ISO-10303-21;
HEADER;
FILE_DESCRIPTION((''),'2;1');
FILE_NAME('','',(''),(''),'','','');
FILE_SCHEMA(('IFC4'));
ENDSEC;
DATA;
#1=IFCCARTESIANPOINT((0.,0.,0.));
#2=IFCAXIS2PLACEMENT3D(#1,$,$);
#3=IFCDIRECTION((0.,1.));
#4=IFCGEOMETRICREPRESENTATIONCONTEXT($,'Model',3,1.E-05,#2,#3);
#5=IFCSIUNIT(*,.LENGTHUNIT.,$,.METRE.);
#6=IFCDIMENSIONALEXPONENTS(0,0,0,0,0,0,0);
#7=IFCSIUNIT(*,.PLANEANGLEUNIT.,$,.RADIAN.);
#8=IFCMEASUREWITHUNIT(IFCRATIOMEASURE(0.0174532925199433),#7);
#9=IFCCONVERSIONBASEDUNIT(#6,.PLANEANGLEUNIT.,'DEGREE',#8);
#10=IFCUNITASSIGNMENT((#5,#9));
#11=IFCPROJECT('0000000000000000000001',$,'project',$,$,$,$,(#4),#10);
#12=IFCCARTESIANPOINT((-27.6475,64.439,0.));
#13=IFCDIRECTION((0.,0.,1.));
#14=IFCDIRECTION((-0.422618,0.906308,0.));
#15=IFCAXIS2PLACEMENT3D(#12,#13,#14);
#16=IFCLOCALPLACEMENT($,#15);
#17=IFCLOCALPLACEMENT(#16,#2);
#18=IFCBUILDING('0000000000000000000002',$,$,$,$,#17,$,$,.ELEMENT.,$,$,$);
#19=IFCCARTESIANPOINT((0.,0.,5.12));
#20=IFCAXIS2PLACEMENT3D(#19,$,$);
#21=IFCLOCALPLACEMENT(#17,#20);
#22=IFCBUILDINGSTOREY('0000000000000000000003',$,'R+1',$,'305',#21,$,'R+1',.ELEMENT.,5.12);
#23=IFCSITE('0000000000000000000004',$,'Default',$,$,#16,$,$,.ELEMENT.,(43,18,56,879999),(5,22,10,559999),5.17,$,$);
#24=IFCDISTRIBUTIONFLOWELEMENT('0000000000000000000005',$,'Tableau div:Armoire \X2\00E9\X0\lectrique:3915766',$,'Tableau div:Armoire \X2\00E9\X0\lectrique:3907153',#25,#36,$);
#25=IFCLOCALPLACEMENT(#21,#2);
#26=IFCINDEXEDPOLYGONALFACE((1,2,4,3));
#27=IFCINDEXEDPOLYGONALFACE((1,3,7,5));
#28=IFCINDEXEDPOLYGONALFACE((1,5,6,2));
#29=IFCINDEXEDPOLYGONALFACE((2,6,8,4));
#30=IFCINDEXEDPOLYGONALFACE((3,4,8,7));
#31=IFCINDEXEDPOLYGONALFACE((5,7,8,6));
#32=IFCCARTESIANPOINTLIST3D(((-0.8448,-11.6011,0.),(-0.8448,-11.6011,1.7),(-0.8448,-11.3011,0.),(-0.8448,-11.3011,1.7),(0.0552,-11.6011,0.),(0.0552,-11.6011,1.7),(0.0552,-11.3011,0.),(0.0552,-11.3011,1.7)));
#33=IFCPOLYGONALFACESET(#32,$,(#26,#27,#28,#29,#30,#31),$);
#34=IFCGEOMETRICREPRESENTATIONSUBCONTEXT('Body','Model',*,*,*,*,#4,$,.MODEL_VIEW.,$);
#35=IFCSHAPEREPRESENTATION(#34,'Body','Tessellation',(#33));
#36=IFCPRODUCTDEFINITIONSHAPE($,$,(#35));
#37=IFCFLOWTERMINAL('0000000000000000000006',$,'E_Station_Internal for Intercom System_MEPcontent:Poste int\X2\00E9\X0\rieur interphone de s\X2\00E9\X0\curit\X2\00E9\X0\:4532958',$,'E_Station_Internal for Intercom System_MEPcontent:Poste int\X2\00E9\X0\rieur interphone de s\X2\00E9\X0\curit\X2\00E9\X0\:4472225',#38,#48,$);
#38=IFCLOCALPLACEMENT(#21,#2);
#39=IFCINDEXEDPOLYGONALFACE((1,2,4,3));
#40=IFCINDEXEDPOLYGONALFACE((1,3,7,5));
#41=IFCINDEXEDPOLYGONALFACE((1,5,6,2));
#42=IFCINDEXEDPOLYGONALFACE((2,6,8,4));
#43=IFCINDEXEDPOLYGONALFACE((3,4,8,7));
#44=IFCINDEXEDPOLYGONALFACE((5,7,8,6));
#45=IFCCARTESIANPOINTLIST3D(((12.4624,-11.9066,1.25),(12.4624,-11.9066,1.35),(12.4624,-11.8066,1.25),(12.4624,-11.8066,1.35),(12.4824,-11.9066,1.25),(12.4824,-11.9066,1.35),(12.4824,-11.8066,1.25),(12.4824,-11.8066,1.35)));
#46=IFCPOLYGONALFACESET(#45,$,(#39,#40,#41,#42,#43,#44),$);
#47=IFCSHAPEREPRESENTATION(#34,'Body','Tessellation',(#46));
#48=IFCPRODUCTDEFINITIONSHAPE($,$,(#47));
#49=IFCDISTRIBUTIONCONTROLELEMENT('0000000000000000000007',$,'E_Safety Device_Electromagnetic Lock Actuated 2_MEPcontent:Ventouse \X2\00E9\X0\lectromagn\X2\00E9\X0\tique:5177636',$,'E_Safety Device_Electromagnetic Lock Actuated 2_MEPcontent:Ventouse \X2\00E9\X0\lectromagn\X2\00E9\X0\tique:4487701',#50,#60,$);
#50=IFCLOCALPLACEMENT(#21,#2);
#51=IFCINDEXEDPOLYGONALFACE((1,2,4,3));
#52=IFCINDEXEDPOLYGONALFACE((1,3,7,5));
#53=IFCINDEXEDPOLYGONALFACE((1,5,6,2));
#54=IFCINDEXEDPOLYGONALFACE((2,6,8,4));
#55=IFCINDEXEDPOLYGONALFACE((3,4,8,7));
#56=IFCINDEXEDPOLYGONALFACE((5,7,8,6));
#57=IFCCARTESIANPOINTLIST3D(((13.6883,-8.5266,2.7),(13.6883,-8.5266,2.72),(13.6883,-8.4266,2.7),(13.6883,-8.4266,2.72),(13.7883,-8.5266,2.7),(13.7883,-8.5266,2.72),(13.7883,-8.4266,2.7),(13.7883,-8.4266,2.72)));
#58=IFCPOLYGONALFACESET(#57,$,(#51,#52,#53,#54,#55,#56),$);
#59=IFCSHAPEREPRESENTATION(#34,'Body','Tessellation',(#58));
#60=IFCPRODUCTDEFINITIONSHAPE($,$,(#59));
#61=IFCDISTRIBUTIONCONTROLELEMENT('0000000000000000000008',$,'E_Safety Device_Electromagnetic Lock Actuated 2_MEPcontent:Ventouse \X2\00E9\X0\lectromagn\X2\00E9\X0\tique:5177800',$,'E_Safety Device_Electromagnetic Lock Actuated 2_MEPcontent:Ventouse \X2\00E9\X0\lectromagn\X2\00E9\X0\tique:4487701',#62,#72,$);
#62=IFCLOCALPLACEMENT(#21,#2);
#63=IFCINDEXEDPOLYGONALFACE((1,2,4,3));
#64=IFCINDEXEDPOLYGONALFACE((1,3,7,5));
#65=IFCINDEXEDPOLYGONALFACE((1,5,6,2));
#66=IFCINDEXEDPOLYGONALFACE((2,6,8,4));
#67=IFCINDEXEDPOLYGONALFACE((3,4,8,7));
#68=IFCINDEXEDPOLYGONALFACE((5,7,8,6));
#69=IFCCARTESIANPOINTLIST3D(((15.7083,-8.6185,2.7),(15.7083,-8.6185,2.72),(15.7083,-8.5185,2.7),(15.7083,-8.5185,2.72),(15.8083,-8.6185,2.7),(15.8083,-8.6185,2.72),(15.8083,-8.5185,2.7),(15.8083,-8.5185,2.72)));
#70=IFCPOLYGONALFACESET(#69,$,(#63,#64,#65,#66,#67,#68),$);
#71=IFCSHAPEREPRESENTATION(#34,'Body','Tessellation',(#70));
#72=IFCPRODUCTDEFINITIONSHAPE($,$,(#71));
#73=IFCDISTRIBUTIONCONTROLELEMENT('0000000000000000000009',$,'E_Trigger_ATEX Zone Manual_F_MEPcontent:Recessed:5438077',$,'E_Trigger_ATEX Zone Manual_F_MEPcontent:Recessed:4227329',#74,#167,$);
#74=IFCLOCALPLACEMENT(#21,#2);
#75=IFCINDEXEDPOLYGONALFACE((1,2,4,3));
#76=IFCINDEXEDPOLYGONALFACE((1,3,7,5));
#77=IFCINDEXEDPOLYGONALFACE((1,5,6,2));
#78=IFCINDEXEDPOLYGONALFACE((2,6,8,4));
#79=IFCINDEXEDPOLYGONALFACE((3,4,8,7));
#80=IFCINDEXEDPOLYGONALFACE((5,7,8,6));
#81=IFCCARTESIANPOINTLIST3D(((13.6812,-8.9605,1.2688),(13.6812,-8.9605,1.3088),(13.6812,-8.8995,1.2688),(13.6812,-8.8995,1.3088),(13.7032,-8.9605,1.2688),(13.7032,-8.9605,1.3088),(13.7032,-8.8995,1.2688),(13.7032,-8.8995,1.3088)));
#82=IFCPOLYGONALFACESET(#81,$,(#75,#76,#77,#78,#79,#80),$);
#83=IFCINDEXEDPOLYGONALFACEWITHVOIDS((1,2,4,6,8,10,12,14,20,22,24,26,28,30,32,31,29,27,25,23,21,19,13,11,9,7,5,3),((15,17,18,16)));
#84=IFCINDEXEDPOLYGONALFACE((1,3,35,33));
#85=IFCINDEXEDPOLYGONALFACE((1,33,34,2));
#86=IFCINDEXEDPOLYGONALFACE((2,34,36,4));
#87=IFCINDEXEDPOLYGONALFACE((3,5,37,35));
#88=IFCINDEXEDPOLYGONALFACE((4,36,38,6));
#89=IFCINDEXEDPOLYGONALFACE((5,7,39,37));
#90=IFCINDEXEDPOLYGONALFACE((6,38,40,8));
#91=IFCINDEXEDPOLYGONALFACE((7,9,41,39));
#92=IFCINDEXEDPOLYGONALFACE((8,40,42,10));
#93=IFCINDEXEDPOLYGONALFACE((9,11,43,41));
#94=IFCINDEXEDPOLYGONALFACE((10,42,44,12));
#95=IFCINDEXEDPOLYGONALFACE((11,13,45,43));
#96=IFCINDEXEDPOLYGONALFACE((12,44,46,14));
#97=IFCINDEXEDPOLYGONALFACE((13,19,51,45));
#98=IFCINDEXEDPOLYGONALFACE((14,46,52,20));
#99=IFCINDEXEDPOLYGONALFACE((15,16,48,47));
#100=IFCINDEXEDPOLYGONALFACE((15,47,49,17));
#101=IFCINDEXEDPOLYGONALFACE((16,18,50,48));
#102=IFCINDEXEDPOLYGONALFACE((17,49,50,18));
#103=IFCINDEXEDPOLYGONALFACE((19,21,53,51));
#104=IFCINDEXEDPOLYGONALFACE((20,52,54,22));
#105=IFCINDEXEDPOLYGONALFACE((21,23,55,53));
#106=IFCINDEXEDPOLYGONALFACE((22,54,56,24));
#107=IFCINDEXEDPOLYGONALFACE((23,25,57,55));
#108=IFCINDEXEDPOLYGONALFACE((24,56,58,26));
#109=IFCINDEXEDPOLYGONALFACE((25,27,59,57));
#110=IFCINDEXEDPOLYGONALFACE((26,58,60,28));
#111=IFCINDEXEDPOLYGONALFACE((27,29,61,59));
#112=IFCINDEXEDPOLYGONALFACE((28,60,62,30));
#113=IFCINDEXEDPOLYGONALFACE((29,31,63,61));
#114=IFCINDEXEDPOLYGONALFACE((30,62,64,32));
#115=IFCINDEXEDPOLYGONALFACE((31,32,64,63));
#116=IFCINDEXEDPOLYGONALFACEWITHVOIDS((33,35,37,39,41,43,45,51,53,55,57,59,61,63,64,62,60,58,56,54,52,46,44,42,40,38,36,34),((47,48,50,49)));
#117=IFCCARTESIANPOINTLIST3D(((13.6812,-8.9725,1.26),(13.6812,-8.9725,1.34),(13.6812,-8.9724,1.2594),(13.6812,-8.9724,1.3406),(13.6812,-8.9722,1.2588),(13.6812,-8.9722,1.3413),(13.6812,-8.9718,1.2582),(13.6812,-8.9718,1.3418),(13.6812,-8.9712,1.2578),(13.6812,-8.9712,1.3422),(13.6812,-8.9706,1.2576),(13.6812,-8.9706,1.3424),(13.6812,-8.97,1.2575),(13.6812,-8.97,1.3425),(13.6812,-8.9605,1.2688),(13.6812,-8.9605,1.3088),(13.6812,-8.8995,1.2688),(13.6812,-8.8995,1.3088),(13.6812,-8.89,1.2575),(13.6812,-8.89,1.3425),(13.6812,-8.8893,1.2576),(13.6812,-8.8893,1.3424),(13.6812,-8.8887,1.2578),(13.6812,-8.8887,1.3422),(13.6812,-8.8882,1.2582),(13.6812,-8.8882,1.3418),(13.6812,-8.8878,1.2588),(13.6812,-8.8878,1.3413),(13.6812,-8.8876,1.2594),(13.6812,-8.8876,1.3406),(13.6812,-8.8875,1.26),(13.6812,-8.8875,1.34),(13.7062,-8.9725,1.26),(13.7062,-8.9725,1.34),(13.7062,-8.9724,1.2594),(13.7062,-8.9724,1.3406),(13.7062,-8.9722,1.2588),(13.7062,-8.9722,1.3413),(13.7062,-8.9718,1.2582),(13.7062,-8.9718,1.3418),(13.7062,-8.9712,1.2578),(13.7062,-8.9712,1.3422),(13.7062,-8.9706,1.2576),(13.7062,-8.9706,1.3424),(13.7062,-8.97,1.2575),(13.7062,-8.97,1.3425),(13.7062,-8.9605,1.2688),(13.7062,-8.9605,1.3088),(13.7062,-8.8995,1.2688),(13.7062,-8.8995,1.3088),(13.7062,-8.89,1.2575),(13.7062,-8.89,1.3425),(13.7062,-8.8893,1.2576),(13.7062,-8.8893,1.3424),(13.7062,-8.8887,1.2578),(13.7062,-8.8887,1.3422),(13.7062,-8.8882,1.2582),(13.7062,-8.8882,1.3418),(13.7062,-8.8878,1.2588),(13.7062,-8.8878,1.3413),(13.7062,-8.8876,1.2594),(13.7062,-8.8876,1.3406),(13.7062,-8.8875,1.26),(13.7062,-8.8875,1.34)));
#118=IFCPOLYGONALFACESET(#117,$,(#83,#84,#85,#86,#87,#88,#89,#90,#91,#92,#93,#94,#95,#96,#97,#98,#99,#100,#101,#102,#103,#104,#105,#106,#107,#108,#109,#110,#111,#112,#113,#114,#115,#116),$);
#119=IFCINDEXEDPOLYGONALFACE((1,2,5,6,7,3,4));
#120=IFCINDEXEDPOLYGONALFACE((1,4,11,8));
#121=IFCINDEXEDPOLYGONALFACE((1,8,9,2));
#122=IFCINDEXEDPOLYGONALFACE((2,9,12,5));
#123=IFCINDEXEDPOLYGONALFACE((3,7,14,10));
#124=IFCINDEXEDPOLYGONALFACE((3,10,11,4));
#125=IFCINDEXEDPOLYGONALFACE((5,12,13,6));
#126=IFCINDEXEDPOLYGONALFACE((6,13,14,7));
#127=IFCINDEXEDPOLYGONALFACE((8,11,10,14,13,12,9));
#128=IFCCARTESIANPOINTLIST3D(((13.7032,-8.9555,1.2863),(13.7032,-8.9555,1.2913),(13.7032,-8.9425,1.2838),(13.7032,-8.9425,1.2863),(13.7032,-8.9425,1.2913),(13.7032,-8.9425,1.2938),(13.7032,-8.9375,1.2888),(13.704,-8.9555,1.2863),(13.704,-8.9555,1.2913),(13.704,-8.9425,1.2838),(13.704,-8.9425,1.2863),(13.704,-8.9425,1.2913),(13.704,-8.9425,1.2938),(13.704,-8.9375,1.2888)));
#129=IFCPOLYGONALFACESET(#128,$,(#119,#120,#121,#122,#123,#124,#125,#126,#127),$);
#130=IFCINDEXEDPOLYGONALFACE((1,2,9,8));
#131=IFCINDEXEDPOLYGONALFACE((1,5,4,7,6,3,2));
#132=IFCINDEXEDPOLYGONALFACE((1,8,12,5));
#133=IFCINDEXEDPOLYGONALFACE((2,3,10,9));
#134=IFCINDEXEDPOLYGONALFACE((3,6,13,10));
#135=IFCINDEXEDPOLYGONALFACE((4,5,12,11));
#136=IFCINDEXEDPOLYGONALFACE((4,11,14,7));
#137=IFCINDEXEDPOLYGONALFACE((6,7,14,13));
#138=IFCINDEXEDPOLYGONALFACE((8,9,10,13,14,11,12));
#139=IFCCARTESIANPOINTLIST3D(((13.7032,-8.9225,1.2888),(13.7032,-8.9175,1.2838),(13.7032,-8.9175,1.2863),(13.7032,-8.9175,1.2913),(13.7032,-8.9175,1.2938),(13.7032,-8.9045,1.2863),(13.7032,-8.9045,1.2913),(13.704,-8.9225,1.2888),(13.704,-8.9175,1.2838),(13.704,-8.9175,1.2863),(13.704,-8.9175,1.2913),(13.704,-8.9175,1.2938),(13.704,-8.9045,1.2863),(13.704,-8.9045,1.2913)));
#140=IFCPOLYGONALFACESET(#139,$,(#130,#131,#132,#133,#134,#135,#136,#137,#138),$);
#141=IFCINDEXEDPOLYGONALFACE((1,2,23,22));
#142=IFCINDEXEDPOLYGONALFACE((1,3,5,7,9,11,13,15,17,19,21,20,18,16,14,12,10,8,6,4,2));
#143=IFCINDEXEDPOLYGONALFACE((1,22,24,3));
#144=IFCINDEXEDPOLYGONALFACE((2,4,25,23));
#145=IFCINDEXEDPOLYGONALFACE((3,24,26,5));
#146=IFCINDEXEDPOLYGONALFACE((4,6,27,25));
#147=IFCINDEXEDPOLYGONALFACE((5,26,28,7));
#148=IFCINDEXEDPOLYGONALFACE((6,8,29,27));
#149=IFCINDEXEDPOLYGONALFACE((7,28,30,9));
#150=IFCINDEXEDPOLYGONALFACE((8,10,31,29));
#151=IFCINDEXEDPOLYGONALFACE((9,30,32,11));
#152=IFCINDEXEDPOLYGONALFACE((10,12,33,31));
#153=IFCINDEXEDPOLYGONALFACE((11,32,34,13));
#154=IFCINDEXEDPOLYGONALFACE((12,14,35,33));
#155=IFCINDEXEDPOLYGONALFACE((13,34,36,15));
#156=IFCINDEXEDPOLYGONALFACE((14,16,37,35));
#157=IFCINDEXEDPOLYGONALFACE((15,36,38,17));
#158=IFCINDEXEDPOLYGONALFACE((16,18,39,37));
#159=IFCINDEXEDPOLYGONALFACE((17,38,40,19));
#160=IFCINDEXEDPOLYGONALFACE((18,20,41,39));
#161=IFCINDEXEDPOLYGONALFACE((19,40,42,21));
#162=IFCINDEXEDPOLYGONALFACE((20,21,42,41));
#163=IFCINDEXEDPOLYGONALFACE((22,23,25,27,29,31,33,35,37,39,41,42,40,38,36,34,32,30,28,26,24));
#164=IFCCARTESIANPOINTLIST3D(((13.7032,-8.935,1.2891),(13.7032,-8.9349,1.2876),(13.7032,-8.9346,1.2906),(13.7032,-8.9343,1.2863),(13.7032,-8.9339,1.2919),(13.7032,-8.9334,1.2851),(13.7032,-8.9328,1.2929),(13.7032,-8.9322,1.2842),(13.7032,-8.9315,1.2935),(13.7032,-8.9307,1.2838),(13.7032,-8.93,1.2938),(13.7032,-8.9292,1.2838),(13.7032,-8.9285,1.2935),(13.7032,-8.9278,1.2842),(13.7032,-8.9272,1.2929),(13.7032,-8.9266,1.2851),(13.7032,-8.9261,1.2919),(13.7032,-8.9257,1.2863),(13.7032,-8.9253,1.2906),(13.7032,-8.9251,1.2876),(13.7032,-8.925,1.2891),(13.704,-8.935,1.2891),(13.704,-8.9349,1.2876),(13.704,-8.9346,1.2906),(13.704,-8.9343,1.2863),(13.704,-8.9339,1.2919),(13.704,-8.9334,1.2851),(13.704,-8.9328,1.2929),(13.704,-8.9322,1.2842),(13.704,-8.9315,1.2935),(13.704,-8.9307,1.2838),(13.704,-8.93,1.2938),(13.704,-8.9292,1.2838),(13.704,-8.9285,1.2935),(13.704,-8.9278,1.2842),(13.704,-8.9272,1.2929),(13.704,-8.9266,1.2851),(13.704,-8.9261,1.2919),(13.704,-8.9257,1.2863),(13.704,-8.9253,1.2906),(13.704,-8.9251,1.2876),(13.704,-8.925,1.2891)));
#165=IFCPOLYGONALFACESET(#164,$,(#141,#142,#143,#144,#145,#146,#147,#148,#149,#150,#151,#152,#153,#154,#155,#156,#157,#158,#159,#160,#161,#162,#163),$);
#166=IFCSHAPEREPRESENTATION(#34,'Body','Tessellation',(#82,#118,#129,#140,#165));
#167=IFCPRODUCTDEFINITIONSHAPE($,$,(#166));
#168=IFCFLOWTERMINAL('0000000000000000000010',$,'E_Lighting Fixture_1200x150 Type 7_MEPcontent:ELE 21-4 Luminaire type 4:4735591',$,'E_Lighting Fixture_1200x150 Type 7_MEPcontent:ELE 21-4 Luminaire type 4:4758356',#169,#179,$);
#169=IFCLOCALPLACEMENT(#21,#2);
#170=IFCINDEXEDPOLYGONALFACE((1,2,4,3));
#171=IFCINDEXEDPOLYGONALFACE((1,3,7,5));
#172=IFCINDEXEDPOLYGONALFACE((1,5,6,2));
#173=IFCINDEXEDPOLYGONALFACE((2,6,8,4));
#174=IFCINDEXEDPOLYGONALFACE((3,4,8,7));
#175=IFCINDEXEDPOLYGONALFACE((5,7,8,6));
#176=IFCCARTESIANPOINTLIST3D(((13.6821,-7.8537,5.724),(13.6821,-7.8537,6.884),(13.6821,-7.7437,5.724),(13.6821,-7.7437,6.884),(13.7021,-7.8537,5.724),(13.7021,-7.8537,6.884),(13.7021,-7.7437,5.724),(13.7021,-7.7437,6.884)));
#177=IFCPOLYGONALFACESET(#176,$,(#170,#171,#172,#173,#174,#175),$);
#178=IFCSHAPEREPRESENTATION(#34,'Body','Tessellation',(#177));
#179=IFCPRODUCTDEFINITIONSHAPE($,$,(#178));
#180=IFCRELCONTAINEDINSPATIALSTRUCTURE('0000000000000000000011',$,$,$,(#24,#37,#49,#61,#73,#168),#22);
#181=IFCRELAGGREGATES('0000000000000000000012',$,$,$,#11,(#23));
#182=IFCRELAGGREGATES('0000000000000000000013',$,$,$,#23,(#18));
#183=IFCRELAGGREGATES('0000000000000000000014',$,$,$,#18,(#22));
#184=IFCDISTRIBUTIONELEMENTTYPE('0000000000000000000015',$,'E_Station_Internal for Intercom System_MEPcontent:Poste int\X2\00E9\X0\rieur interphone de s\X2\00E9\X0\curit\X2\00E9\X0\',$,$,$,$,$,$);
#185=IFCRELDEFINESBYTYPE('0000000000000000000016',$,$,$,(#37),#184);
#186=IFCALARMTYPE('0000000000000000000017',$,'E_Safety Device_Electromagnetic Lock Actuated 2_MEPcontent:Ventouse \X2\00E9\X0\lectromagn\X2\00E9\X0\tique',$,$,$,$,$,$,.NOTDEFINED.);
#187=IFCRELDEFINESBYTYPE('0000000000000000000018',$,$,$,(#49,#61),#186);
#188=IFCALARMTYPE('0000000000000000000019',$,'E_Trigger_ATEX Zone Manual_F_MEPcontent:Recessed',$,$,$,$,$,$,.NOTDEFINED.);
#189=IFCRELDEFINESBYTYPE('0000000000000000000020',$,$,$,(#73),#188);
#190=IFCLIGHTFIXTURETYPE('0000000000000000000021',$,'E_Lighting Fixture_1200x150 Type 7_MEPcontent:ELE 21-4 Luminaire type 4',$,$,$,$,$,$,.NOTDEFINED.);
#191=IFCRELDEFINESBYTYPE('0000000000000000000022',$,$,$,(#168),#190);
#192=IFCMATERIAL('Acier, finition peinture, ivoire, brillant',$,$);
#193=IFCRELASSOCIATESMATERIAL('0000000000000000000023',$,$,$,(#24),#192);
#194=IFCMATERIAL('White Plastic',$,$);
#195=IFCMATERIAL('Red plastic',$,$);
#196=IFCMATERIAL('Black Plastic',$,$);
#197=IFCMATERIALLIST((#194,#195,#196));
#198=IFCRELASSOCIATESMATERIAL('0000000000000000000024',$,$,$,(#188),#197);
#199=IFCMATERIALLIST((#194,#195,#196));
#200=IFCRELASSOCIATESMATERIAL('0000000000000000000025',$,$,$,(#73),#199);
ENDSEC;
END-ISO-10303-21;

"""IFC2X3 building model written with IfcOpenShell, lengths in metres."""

from ifc_helpers import new_model, entity, si_unit, converted_unit, direction, frame, frame_2d, origin, origin_2d_with_axis, place, context, subcontext, project, spatial, polyline, circle_curve, parameter, trimmed, segment, composite_curve, rectangle, circle, outline, extrude, source, transform, mapped, material, material_list, type_object, type_shapes, element, save


model = new_model("IFC2X3")

# Units and contexts
model_context = context("Model", 3, precision=1e-05, world=origin(), true_north=direction((0.0, 1.0)))
body_context = subcontext(model_context, "Body", "Model", "MODEL_VIEW")
ifc_project = project(units=[si_unit("LENGTHUNIT", "METRE"), converted_unit("PLANEANGLEUNIT", "DEGREE", entity("IfcRatioMeasure", 0.0174532925199433), si_unit("PLANEANGLEUNIT", "RADIAN"), dimensions=[0, 0, 0, 0, 0, 0, 0])], contexts=[model_context])

# Site, building, storey
site_placement = place(None, frame((-27.6475, 64.439, 0.0), z_axis=(0.0, 0.0, 1.0), x_axis=(-0.422618, 0.906308, 0.0)))
site = spatial("IfcSite", under=ifc_project, at=site_placement, Name="Default", CompositionType="ELEMENT", RefLatitude=(43, 18, 56, 879999), RefLongitude=(5, 22, 10, 559999), RefElevation=5.17)
building_placement = place(site_placement, origin())
building = spatial("IfcBuilding", under=site, at=building_placement, CompositionType="ELEMENT")
storey_placement = place(building_placement, frame((0.0, 0.0, 5.12)))
storey = spatial("IfcBuildingStorey", under=building, at=storey_placement, Name="R+1", ObjectType="305", LongName="R+1", CompositionType="ELEMENT", Elevation=5.12)

# Distribution flow element
ifc_material_1 = material(Name="Acier, finition peinture, ivoire, brillant")
shared_shape_1 = source(origin(), body_context, "Body", "SweptSolid", [
    extrude(rectangle(XDim=0.9, YDim=0.3, at=origin_2d_with_axis()), frame((0.0, -0.45, 0.0), z_axis=(0.0, 0.0, 1.0), x_axis=(0.0, 1.0, 0.0)), (0.0, 0.0, 1.0), 1.7),
])
distribution_flow_element_placement = place(storey_placement, frame((0.0552, -11.4511, 0.0), z_axis=(0.0, 0.0, 1.0), x_axis=(0.0, -1.0, 0.0)))
element("IfcDistributionFlowElement", 1, at=distribution_flow_element_placement, inside=storey, material=ifc_material_1, Name="Tableau div:Armoire électrique:3915766", ObjectType="Tableau div:Armoire électrique:3907153", context=body_context, shape_type="MappedRepresentation", body=[
    mapped(shared_shape_1, transform((0.0, 0.0, 0.0), scale=1.0)),
])

# Flow terminal
distribution_element_type_1 = type_object("IfcDistributionElementType", Name="E_Station_Internal for Intercom System_MEPcontent:Poste intérieur interphone de sécurité")
shared_shape_2 = source(origin(), body_context, "Body", "SweptSolid", [
    extrude(rectangle(XDim=0.02, YDim=0.1, at=frame_2d((0.0, 0.0), x_axis=(1.0, 0.0))), frame((0.0, -0.01, -0.05), z_axis=(0.0, 0.0, 1.0), x_axis=(0.0, 1.0, 0.0)), (0.0, 0.0, 1.0), 0.1),
])
type_shapes(distribution_element_type_1, [shared_shape_2])
flow_terminal_1_placement = place(storey_placement, frame((12.4824, -11.8566, 1.3), z_axis=(0.0, 0.0, 1.0), x_axis=(0.0, -1.0, 0.0)))
element("IfcFlowTerminal", 2, at=flow_terminal_1_placement, inside=storey, type_object=distribution_element_type_1, Name="E_Station_Internal for Intercom System_MEPcontent:Poste intérieur interphone de sécurité:4532958", ObjectType="E_Station_Internal for Intercom System_MEPcontent:Poste intérieur interphone de sécurité:4472225", context=body_context, shape_type="MappedRepresentation", body=[
    mapped(shared_shape_2, transform((0.0, 0.0, 0.0), scale=1.0)),
])

# Distribution control elements
alarm_type_1 = type_object("IfcAlarmType", Name="E_Safety Device_Electromagnetic Lock Actuated 2_MEPcontent:Ventouse électromagnétique", PredefinedType="NOTDEFINED")
shared_shape_3 = source(origin(), body_context, "Body", "SweptSolid", [
    extrude(rectangle(XDim=0.1, YDim=0.1, at=origin_2d_with_axis()), frame((0.0, 0.0, 0.0), z_axis=(0.0, 0.0, 1.0), x_axis=(0.0, -1.0, 0.0)), (0.0, 0.0, 1.0), 0.02),
])
type_shapes(alarm_type_1, [shared_shape_3])
distribution_control_element_1_placement = place(storey_placement, frame((13.7383, -8.4766, 2.7), z_axis=(0.0, 0.0, 1.0), x_axis=(0.0, -1.0, 0.0)))
element("IfcDistributionControlElement", 3, at=distribution_control_element_1_placement, inside=storey, type_object=alarm_type_1, Name="E_Safety Device_Electromagnetic Lock Actuated 2_MEPcontent:Ventouse électromagnétique:5177636", ObjectType="E_Safety Device_Electromagnetic Lock Actuated 2_MEPcontent:Ventouse électromagnétique:4487701", context=body_context, shape_type="MappedRepresentation", body=[
    mapped(shared_shape_3, transform((0.0, 0.0, 0.0), scale=1.0)),
])
distribution_control_element_2_placement = place(storey_placement, frame((15.7583, -8.5685, 2.7)))
element("IfcDistributionControlElement", 4, at=distribution_control_element_2_placement, inside=storey, type_object=alarm_type_1, Name="E_Safety Device_Electromagnetic Lock Actuated 2_MEPcontent:Ventouse électromagnétique:5177800", ObjectType="E_Safety Device_Electromagnetic Lock Actuated 2_MEPcontent:Ventouse électromagnétique:4487701", context=body_context, shape_type="MappedRepresentation", body=[
    mapped(shared_shape_3, transform((0.0, 0.0, 0.0), scale=1.0)),
])
ifc_material_2 = material(Name="White Plastic")
ifc_material_3 = material(Name="Red plastic")
ifc_material_4 = material(Name="Black Plastic")
ifc_material_list_1 = material_list([ifc_material_2, ifc_material_3, ifc_material_4])
ifc_material_list_2 = material_list([ifc_material_2, ifc_material_3, ifc_material_4])
alarm_type_2 = type_object("IfcAlarmType", Name="E_Trigger_ATEX Zone Manual_F_MEPcontent:Recessed", PredefinedType="NOTDEFINED", material=ifc_material_list_2)
shared_shape_4 = source(origin(), body_context, "Body", "SweptSolid", [
    extrude(rectangle(XDim=0.061, YDim=0.04, at=origin_2d_with_axis()), frame((0.0, -0.0112, 0.0), z_axis=(0.0, 0.0, 1.0), x_axis=(-1.0, 0.0, 0.0)), (0.0, 0.0, 1.0), 0.022),
    extrude(outline(composite_curve([segment(polyline([(-0.04, -0.0425), (0.04, -0.0425)]), True, "CONTINUOUS"), segment(trimmed(circle_curve(frame_2d((0.04, -0.04), x_axis=(-1.0, 0.0)), 0.0025), [parameter(90.0)], [parameter(180.0)], True, "PARAMETER"), True, "CONTINUOUS"), segment(polyline([(0.0425, -0.04), (0.0425, 0.04)]), True, "CONTINUOUS"), segment(trimmed(circle_curve(frame_2d((0.04, 0.04), x_axis=(-1.0, 0.0)), 0.0025), [parameter(180.0)], [parameter(270.0)], True, "PARAMETER"), True, "CONTINUOUS"), segment(polyline([(0.04, 0.0425), (-0.04, 0.0425)]), True, "CONTINUOUS"), segment(trimmed(circle_curve(frame_2d((-0.04, 0.04), x_axis=(-1.0, 0.0)), 0.0025), [parameter(270.0)], [parameter(0.0)], True, "PARAMETER"), True, "CONTINUOUS"), segment(polyline([(-0.0425, 0.04), (-0.0425, -0.04)]), True, "CONTINUOUS"), segment(trimmed(circle_curve(frame_2d((-0.04, -0.04), x_axis=(-1.0, 0.0)), 0.0025), [parameter(360.0)], [parameter(90.0)], True, "PARAMETER"), True, "CONTINUOUS")], self_intersect=False), holes=[polyline([(-0.0305, -0.0088), (-0.0305, 0.0312), (0.0305, 0.0312), (0.0305, -0.0088), (-0.0305, -0.0088)])]), frame((0.0, 0.0, 0.0), z_axis=(0.0, 0.0, 1.0), x_axis=(-1.0, 0.0, 0.0)), (0.0, 0.0, 1.0), 0.025),
    extrude(outline(polyline([(-0.01, 0.0025), (-0.01, -0.0025), (0.003, -0.0025), (0.003, -0.005), (0.008, 0.0), (0.003, 0.005), (0.003, 0.0025), (-0.01, 0.0025)])), frame((-0.0155, -0.0112, 0.022), z_axis=(0.0, 0.0, -1.0), x_axis=(1.0, 0.0, 0.0)), (0.0, 0.0, -1.0), 0.0008),
    extrude(outline(polyline([(-0.0014, -0.0057), (0.0057, -0.0057), (0.0057, 0.0014), (0.0039, -0.0004), (-0.0053, 0.0088), (-0.0088, 0.0053), (0.0004, -0.0039), (-0.0014, -0.0057)])), frame((0.0155, -0.0112, 0.022), z_axis=(0.0, 0.0, 1.0), x_axis=(-0.707107, -0.707107, 0.0)), (0.0, 0.0, 1.0), 0.0008),
    extrude(circle(Radius=0.005, at=frame_2d((0.0, 0.0), x_axis=(1.0, 0.0))), frame((0.0, -0.0112, 0.022), z_axis=(0.0, 0.0, 1.0), x_axis=(0.0, 1.0, 0.0)), (0.0, 0.0, 1.0), 0.0008),
])
type_shapes(alarm_type_2, [shared_shape_4])
distribution_control_element_3_placement = place(storey_placement, frame((13.6812, -8.93, 1.3), z_axis=(1.0, 0.0, 0.0), x_axis=(0.0, 1.0, 0.0)))
element("IfcDistributionControlElement", 5, at=distribution_control_element_3_placement, inside=storey, type_object=alarm_type_2, material=ifc_material_list_1, Name="E_Trigger_ATEX Zone Manual_F_MEPcontent:Recessed:5438077", ObjectType="E_Trigger_ATEX Zone Manual_F_MEPcontent:Recessed:4227329", context=body_context, shape_type="MappedRepresentation", body=[
    mapped(shared_shape_4, transform((0.0, 0.0, 0.0), scale=1.0)),
])

# Flow terminal
light_fixture_type_1 = type_object("IfcLightFixtureType", Name="E_Lighting Fixture_1200x150 Type 7_MEPcontent:ELE 21-4 Luminaire type 4", PredefinedType="NOTDEFINED")
shared_shape_5 = source(origin(), body_context, "Body", "SweptSolid", [
    extrude(rectangle(XDim=0.02, YDim=0.11, at=frame_2d((0.0, 0.0), x_axis=(1.0, 0.0))), frame((0.0, 0.01, -0.58), z_axis=(0.0, 0.0, 1.0), x_axis=(0.0, -1.0, 0.0)), (0.0, 0.0, 1.0), 1.16),
])
type_shapes(light_fixture_type_1, [shared_shape_5])
flow_terminal_2_placement = place(storey_placement, frame((13.6821, -7.7987, 6.304), z_axis=(0.0, 0.0, 1.0), x_axis=(0.0, -1.0, 0.0)))
element("IfcFlowTerminal", 6, at=flow_terminal_2_placement, inside=storey, type_object=light_fixture_type_1, Name="E_Lighting Fixture_1200x150 Type 7_MEPcontent:ELE 21-4 Luminaire type 4:4735591", ObjectType="E_Lighting Fixture_1200x150 Type 7_MEPcontent:ELE 21-4 Luminaire type 4:4758356", context=body_context, shape_type="MappedRepresentation", body=[
    mapped(shared_shape_5, transform((0.0, 0.0, 0.0), scale=1.0)),
])

save(model, "model.ifc")
